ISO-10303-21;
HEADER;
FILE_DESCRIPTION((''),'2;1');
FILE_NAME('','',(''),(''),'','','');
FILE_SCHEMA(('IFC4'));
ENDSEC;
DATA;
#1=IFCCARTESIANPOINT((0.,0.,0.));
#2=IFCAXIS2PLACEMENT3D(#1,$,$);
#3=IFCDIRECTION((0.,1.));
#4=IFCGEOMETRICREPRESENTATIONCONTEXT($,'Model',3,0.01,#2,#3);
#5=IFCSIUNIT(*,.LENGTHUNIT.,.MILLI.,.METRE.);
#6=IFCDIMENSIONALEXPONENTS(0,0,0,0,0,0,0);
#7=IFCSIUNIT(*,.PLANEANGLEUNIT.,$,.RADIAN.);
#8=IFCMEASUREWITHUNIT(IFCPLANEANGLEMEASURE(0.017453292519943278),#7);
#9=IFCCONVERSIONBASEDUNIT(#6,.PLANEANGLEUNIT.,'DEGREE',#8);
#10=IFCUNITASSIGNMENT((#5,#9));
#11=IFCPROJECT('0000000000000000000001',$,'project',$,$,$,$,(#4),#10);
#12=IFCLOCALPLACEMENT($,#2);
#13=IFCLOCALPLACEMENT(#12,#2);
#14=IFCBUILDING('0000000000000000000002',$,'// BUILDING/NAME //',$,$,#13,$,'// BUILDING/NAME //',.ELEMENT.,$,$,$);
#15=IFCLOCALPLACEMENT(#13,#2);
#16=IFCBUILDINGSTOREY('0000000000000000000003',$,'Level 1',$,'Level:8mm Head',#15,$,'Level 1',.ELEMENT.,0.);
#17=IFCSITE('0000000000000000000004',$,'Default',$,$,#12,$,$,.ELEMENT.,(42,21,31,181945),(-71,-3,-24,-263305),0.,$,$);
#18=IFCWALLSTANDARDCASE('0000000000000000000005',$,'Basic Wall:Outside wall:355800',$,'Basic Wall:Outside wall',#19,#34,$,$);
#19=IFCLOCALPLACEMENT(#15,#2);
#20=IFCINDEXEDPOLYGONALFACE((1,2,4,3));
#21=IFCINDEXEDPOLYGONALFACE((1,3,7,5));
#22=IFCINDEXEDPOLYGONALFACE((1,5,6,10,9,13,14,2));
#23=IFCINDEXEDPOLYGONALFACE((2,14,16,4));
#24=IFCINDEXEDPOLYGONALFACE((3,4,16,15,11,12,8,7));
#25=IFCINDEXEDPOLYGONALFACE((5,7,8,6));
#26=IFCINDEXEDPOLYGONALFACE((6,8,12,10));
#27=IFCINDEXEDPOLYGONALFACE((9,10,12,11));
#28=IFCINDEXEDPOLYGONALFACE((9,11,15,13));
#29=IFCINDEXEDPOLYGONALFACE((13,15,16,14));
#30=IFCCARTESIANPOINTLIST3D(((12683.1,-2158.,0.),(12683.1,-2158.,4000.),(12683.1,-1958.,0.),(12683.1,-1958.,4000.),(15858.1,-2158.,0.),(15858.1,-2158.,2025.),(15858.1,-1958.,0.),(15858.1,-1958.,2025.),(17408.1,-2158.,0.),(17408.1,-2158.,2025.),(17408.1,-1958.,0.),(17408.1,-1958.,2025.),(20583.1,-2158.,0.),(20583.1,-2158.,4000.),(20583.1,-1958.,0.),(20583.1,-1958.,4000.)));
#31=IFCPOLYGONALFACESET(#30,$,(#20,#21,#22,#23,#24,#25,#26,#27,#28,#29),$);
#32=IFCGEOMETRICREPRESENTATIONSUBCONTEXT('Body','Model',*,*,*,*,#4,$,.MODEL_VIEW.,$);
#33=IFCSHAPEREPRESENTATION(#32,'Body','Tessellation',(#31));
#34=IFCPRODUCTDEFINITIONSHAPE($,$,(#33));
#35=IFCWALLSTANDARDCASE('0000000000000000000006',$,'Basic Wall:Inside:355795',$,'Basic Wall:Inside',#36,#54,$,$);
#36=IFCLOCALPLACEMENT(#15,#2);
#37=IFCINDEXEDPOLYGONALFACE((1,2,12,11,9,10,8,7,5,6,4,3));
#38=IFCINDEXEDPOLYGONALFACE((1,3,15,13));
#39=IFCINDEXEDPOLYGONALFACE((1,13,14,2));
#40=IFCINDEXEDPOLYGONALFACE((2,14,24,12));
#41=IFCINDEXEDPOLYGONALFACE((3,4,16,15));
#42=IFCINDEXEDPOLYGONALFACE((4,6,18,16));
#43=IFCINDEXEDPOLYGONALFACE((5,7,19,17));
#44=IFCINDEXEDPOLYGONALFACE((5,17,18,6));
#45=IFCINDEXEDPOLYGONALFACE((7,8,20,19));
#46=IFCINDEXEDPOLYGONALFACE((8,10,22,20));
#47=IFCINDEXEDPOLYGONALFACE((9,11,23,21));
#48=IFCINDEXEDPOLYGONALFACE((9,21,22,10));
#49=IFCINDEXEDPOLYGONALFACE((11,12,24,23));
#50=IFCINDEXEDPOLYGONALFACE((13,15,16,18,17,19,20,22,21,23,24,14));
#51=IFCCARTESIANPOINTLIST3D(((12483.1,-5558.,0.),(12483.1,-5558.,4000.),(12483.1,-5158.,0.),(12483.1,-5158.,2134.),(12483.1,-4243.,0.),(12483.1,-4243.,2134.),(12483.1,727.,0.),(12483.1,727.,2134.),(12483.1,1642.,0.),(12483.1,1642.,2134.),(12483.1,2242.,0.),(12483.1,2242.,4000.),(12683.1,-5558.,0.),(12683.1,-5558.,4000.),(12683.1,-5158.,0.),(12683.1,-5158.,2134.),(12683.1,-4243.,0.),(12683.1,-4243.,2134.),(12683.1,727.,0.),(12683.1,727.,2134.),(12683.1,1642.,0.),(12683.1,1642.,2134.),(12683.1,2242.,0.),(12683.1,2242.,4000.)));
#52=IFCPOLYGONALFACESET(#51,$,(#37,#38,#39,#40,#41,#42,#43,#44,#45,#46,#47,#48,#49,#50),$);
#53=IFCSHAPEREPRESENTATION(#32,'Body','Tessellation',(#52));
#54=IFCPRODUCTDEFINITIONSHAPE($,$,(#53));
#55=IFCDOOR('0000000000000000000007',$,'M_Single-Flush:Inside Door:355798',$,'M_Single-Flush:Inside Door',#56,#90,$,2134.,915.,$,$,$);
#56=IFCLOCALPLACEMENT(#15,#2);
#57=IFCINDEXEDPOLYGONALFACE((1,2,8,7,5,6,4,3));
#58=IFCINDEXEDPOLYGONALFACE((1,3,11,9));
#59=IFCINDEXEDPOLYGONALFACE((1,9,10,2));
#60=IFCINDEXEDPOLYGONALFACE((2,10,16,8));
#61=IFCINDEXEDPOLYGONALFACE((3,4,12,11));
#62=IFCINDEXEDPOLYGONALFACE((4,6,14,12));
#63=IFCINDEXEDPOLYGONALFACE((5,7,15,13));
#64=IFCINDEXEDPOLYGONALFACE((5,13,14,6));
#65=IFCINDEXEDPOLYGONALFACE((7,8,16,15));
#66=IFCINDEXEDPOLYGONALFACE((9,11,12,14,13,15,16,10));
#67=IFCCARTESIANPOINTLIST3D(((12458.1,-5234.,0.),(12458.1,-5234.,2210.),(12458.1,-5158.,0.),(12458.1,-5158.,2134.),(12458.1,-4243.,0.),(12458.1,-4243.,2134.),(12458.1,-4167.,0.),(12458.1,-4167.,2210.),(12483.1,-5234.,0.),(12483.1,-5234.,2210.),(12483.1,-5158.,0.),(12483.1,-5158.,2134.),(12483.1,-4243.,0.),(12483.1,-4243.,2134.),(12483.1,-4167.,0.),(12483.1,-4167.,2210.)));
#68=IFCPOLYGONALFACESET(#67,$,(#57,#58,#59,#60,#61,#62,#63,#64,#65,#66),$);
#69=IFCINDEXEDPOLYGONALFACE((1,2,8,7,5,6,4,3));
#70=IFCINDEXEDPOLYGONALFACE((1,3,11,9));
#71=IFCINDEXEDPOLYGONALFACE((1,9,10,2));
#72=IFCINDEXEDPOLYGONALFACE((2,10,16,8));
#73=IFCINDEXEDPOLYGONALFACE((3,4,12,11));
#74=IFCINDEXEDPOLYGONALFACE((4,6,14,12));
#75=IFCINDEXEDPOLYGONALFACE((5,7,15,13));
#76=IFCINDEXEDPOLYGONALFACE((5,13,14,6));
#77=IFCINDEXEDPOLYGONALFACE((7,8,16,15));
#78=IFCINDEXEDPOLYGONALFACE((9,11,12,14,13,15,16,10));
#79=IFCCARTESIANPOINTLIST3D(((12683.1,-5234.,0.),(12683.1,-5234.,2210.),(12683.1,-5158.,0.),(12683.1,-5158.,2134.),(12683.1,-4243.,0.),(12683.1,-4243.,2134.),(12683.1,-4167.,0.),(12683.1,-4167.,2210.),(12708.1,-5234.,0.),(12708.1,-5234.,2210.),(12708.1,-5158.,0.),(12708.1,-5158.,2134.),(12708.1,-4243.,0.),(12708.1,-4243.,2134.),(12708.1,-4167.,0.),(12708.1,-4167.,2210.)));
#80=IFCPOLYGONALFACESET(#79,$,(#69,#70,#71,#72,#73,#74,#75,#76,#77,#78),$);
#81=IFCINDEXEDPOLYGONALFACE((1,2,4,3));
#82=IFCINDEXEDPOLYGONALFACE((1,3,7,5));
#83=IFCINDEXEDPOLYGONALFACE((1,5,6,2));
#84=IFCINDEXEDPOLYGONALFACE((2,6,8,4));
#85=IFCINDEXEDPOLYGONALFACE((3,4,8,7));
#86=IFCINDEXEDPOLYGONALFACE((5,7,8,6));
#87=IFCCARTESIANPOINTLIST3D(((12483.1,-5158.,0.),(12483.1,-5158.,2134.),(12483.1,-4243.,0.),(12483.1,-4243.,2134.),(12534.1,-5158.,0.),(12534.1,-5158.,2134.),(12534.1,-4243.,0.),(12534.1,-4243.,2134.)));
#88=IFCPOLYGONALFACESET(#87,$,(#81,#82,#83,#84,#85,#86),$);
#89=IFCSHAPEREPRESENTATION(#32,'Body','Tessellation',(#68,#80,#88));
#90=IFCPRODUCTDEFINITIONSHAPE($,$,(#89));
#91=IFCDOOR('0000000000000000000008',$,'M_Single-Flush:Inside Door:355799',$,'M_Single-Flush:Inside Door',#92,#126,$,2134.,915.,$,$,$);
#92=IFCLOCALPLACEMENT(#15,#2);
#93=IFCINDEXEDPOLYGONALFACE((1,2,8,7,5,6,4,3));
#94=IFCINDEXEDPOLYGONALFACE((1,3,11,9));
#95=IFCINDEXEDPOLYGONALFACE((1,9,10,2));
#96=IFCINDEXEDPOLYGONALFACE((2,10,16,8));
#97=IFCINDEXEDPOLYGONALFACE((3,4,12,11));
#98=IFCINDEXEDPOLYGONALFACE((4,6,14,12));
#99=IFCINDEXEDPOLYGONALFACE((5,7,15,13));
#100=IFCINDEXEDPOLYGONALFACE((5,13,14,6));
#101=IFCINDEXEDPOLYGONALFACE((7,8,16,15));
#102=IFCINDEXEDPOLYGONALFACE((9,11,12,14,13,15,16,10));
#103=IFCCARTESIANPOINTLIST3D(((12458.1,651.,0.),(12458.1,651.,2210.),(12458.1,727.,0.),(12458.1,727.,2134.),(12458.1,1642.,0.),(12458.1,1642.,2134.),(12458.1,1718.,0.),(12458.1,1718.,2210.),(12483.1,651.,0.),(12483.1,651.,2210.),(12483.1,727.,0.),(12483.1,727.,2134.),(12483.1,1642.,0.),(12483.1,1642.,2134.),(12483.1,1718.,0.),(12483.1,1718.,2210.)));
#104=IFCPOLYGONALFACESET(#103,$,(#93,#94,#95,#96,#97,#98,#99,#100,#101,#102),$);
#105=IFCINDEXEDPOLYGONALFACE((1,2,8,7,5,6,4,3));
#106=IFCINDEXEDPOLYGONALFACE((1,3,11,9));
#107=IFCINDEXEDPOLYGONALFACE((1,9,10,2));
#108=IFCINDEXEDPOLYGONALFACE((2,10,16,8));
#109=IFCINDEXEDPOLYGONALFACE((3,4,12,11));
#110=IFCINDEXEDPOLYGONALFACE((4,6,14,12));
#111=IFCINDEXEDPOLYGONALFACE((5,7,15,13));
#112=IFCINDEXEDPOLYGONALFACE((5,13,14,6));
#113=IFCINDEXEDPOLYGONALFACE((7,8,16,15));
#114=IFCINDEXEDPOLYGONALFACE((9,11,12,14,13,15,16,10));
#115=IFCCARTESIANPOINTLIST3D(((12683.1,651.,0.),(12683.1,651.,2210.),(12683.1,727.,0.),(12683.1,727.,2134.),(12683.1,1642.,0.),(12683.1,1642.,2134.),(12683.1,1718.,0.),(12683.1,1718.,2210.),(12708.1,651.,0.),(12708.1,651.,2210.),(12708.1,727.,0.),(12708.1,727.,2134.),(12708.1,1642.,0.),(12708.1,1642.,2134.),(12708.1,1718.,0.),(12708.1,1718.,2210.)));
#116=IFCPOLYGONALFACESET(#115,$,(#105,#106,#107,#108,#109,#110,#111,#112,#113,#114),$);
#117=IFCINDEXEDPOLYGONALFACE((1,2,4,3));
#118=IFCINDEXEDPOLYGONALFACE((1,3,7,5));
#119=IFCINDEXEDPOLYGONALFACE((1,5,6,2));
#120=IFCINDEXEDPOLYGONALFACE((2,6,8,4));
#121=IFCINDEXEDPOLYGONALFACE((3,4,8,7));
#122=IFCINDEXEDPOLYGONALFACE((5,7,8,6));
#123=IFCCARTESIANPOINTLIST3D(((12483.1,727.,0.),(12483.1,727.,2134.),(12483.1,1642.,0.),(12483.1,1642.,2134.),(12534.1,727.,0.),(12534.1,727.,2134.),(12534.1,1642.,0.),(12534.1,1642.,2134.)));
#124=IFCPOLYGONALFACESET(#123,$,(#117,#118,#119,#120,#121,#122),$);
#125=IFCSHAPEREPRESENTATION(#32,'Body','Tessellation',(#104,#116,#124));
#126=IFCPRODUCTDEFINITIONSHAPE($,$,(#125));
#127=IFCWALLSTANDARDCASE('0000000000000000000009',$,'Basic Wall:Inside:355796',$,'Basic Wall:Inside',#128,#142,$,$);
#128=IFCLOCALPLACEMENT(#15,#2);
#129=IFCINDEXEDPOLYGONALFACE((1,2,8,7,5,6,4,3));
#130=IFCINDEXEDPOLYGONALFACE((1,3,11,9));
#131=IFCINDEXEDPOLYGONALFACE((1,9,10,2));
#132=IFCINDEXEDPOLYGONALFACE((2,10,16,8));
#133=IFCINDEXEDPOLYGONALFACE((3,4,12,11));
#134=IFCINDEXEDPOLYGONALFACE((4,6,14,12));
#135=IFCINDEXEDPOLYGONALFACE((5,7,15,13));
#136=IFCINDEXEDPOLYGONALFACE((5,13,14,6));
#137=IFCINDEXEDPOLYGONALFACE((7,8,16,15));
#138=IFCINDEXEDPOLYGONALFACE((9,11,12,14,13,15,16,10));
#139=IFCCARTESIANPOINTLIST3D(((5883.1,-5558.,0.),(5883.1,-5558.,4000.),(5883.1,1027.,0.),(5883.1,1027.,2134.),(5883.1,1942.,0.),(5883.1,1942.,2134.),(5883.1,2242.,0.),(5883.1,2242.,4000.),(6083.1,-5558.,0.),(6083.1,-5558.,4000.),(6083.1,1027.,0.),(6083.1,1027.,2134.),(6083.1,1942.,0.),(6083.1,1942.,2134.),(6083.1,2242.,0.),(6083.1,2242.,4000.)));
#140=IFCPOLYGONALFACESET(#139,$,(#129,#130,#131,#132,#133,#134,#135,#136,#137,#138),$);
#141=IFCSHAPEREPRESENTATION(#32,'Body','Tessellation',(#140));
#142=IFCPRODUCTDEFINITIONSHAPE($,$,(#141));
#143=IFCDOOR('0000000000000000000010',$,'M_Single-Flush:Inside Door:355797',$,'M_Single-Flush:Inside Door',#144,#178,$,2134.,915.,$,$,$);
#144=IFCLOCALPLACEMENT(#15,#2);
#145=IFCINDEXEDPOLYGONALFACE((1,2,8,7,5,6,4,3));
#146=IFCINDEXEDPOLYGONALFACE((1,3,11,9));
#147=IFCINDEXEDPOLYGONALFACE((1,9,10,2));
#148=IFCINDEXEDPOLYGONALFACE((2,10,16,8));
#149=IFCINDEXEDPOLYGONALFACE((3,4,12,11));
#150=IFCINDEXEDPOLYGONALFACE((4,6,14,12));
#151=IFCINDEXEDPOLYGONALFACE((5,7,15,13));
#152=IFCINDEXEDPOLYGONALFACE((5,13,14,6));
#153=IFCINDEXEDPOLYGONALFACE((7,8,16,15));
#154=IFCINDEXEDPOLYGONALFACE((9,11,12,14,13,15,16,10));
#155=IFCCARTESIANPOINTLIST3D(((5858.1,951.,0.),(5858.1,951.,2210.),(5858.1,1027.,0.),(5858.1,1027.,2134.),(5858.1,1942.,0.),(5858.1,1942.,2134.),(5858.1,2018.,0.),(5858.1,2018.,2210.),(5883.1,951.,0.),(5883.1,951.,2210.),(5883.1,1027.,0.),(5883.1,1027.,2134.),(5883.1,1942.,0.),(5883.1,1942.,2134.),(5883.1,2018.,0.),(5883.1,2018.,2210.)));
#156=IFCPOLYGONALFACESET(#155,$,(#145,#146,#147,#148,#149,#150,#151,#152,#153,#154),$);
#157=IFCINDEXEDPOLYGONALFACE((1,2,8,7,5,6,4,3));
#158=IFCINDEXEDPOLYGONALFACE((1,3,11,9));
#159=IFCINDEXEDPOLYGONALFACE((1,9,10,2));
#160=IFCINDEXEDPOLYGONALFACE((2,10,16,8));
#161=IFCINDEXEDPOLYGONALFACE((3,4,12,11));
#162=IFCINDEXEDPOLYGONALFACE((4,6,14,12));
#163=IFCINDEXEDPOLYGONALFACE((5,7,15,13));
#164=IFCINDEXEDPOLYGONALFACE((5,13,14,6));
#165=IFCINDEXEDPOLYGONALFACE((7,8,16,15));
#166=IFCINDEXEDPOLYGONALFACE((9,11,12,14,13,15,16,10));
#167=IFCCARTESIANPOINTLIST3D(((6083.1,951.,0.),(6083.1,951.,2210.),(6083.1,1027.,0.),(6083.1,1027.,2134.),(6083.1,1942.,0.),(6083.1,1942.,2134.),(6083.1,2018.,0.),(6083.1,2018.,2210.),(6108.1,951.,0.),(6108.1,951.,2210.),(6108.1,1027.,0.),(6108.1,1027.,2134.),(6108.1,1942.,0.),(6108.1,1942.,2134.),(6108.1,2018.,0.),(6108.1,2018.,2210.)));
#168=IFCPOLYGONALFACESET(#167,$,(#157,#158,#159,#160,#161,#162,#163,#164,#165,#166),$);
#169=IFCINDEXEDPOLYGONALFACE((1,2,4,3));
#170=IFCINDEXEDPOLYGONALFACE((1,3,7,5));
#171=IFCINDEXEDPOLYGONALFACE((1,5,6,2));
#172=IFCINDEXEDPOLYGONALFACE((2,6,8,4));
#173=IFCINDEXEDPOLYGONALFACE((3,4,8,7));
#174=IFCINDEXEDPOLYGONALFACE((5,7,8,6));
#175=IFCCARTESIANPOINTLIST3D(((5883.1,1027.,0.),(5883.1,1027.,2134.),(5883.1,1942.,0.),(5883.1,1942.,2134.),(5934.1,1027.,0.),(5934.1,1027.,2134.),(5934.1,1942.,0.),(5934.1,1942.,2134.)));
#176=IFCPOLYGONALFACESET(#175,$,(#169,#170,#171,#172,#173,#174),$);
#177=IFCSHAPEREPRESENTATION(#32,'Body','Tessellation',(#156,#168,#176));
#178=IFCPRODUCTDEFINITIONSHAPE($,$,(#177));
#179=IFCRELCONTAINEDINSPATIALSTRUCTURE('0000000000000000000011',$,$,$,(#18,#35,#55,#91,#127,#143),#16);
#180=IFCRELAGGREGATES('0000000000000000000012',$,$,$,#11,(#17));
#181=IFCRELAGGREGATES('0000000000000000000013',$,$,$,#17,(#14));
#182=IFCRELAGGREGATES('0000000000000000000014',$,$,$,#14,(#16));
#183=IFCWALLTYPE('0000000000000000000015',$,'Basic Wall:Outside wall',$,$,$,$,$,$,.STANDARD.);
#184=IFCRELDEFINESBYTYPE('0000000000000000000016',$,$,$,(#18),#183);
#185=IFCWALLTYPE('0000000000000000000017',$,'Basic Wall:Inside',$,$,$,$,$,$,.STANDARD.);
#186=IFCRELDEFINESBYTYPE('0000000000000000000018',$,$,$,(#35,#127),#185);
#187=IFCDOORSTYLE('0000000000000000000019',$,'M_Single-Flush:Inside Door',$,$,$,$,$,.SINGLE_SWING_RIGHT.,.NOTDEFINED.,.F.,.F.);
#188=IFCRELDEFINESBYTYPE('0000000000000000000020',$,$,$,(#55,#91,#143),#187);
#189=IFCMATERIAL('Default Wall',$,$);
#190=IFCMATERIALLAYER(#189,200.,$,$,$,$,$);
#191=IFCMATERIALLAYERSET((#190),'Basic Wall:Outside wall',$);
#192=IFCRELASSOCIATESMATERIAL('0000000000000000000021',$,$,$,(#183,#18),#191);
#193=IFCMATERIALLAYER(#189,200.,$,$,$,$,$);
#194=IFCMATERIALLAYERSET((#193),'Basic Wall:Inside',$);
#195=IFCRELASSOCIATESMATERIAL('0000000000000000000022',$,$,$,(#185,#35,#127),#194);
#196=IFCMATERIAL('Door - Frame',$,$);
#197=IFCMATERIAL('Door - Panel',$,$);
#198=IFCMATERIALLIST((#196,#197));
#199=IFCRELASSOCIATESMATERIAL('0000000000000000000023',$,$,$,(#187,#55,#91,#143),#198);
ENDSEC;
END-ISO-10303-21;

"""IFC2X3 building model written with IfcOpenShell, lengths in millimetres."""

from ifc_helpers import new_model, entity, si_unit, converted_unit, direction, frame, frame_2d, origin, place, context, subcontext, project, spatial, polyline, rectangle, outline, extrude, source, transform, mapped, material, material_list, layer, layer_set, layer_usage, type_object, type_shapes, element, fill, save


model = new_model("IFC2X3")

# Units and contexts
model_context = context("Model", 3, precision=0.01, world=origin(), true_north=direction((0.0, 1.0)))
body_context = subcontext(model_context, "Body", "Model", "MODEL_VIEW")
ifc_project = project(units=[si_unit("LENGTHUNIT", "METRE", prefix="MILLI"), converted_unit("PLANEANGLEUNIT", "DEGREE", entity("IfcPlaneAngleMeasure", 0.017453292519943278), si_unit("PLANEANGLEUNIT", "RADIAN"), dimensions=[0, 0, 0, 0, 0, 0, 0])], contexts=[model_context])

# Site, building, storey
site_placement = place(None, origin())
site = spatial("IfcSite", under=ifc_project, at=site_placement, Name="Default", CompositionType="ELEMENT", RefLatitude=(42, 21, 31, 181945), RefLongitude=(-71, -3, -24, -263305), RefElevation=0.0)
building_placement = place(site_placement, origin())
building = spatial("IfcBuilding", under=site, at=building_placement, Name="// BUILDING/NAME //", LongName="// BUILDING/NAME //", CompositionType="ELEMENT")
storey_placement = place(building_placement, origin())
storey = spatial("IfcBuildingStorey", under=building, at=storey_placement, Name="Level 1", ObjectType="Level:8mm Head", LongName="Level 1", CompositionType="ELEMENT", Elevation=0.0)

# Wall, opening
ifc_material_1 = material(Name="Default Wall")
ifc_layer_1 = layer(ifc_material_1, 200.0)
ifc_layer_set_1 = layer_set([ifc_layer_1], Name="Basic Wall:Outside wall")
ifc_layer_usage_1 = layer_usage(ifc_layer_set_1, "AXIS2", "NEGATIVE", 100.0)
wall_type_1 = type_object("IfcWallType", Name="Basic Wall:Outside wall", PredefinedType="STANDARD", material=ifc_layer_set_1)
wall_1_placement = place(storey_placement, frame((12683.1, -2058.0, 0.0)))
wall_1 = element("IfcWallStandardCase", 1, at=wall_1_placement, inside=storey, type_object=wall_type_1, material=ifc_layer_usage_1, Name="Basic Wall:Outside wall:355800", ObjectType="Basic Wall:Outside wall", context=body_context, shape_type="SweptSolid", body=[
    extrude(rectangle(XDim=7900.0, YDim=200.0, at=frame_2d((3950.0, 0.0), x_axis=(1.0, 0.0))), origin(), (0.0, 0.0, 1.0), 4000.0),
])
opening_1_placement = place(wall_1_placement, frame((4725.0, 100.0, 0.0)))
element("IfcOpeningElement", 2, at=opening_1_placement, cuts=wall_1, ObjectType="Opening", context=body_context, shape_type="SweptSolid", body=[
    extrude(rectangle(XDim=2025.0, YDim=1550.0, at=frame_2d((1012.5, 775.0), x_axis=(1.0, 0.0))), frame((0.0, 0.0, 0.0), z_axis=(0.0, -1.0, 0.0), x_axis=(0.0, 0.0, 1.0)), (0.0, 0.0, 1.0), 200.0),
])

# Wall, openings, doors
ifc_layer_2 = layer(ifc_material_1, 200.0)
ifc_layer_set_2 = layer_set([ifc_layer_2], Name="Basic Wall:Inside")
ifc_layer_usage_2 = layer_usage(ifc_layer_set_2, "AXIS2", "NEGATIVE", 100.0)
wall_type_2 = type_object("IfcWallType", Name="Basic Wall:Inside", PredefinedType="STANDARD", material=ifc_layer_set_2)
wall_2_placement = place(storey_placement, frame((12583.1, -5558.0, 0.0), z_axis=(0.0, 0.0, 1.0), x_axis=(0.0, 1.0, 0.0)))
wall_2 = element("IfcWallStandardCase", 3, at=wall_2_placement, inside=storey, type_object=wall_type_2, material=ifc_layer_usage_2, Name="Basic Wall:Inside:355795", ObjectType="Basic Wall:Inside", context=body_context, shape_type="SweptSolid", body=[
    extrude(rectangle(XDim=7800.0, YDim=200.0, at=frame_2d((3900.0, 0.0), x_axis=(1.0, 0.0))), origin(), (0.0, 0.0, 1.0), 4000.0),
])
opening_2_placement = place(wall_2_placement, frame((400.0, -100.0, 0.0)))
opening_2 = element("IfcOpeningElement", 4, at=opening_2_placement, cuts=wall_2, ObjectType="Opening", context=body_context, shape_type="SweptSolid", body=[
    extrude(rectangle(XDim=915.0, YDim=2134.0, at=frame_2d((1067.0, 457.5), x_axis=(0.0, 1.0))), frame((0.0, 0.0, 0.0), z_axis=(0.0, 1.0, 0.0), x_axis=(0.0, 0.0, 1.0)), (0.0, 0.0, 1.0), 200.0),
])
opening_3_placement = place(wall_2_placement, frame((6285.0, -100.0, 0.0)))
opening_3 = element("IfcOpeningElement", 5, at=opening_3_placement, cuts=wall_2, ObjectType="Opening", context=body_context, shape_type="SweptSolid", body=[
    extrude(rectangle(XDim=915.0, YDim=2134.0, at=frame_2d((1067.0, 457.5), x_axis=(0.0, 1.0))), frame((0.0, 0.0, 0.0), z_axis=(0.0, 1.0, 0.0), x_axis=(0.0, 0.0, 1.0)), (0.0, 0.0, 1.0), 200.0),
])
ifc_material_2 = material(Name="Door - Frame")
ifc_material_3 = material(Name="Door - Panel")
ifc_material_list = material_list([ifc_material_2, ifc_material_3])
door_style = type_object("IfcDoorStyle", Name="M_Single-Flush:Inside Door", ConstructionType="NOTDEFINED", OperationType="SINGLE_SWING_RIGHT", ParameterTakesPrecedence=False, Sizeable=False, material=ifc_material_list)
shared_shape = source(origin(), body_context, "Body", "SweptSolid", [
    extrude(outline(polyline([(-533.5, -1124.0), (533.5, -1124.0), (533.5, 1086.0), (457.5, 1086.0), (457.5, -1048.0), (-457.5, -1048.0), (-457.5, 1086.0), (-533.5, 1086.0), (-533.5, -1124.0)])), frame((457.5, 200.0, 1086.0), z_axis=(0.0, 1.0, 0.0), x_axis=(1.0, 0.0, 0.0)), (0.0, 0.0, 1.0), 25.0),
    extrude(outline(polyline([(-1124.0, -533.5), (1086.0, -533.5), (1086.0, -457.5), (-1048.0, -457.5), (-1048.0, 457.5), (1086.0, 457.5), (1086.0, 533.5), (-1124.0, 533.5), (-1124.0, -533.5)])), frame((457.5, -25.0, 1086.0), z_axis=(0.0, 1.0, 0.0), x_axis=(0.0, 0.0, -1.0)), (0.0, 0.0, 1.0), 25.0),
    extrude(rectangle(XDim=51.0, YDim=915.0, at=frame_2d((0.0, 0.0), x_axis=(1.0, 0.0))), frame((457.5, 174.5, 0.0), z_axis=(0.0, 0.0, 1.0), x_axis=(0.0, 1.0, 0.0)), (0.0, 0.0, 1.0), 2134.0),
])
type_shapes(door_style, [shared_shape])
door_1_placement = place(opening_2_placement, origin())
door_1 = element("IfcDoor", 6, at=door_1_placement, inside=storey, type_object=door_style, material=ifc_material_list, Name="M_Single-Flush:Inside Door:355798", ObjectType="M_Single-Flush:Inside Door", OverallHeight=2134.0, OverallWidth=915.0, context=body_context, shape_type="MappedRepresentation", body=[
    mapped(shared_shape, transform((0.0, 0.0, 0.0), scale=1.0)),
])
fill(opening_2, door_1)
door_2_placement = place(opening_3_placement, origin())
door_2 = element("IfcDoor", 7, at=door_2_placement, inside=storey, type_object=door_style, material=ifc_material_list, Name="M_Single-Flush:Inside Door:355799", ObjectType="M_Single-Flush:Inside Door", OverallHeight=2134.0, OverallWidth=915.0, context=body_context, shape_type="MappedRepresentation", body=[
    mapped(shared_shape, transform((0.0, 0.0, 0.0), scale=1.0)),
])
fill(opening_3, door_2)

# Wall, opening, door
wall_3_placement = place(storey_placement, frame((5983.1, -5558.0, 0.0), z_axis=(0.0, 0.0, 1.0), x_axis=(0.0, 1.0, 0.0)))
wall_3 = element("IfcWallStandardCase", 8, at=wall_3_placement, inside=storey, type_object=wall_type_2, material=ifc_layer_usage_2, Name="Basic Wall:Inside:355796", ObjectType="Basic Wall:Inside", context=body_context, shape_type="SweptSolid", body=[
    extrude(rectangle(XDim=7800.0, YDim=200.0, at=frame_2d((3900.0, 0.0), x_axis=(-1.0, 0.0))), origin(), (0.0, 0.0, 1.0), 4000.0),
])
opening_4_placement = place(wall_3_placement, frame((6585.0, -100.0, 0.0)))
opening_4 = element("IfcOpeningElement", 9, at=opening_4_placement, cuts=wall_3, ObjectType="Opening", context=body_context, shape_type="SweptSolid", body=[
    extrude(rectangle(XDim=915.0, YDim=2134.0, at=frame_2d((1067.0, 457.5), x_axis=(0.0, 1.0))), frame((0.0, 0.0, 0.0), z_axis=(0.0, 1.0, 0.0), x_axis=(0.0, 0.0, 1.0)), (0.0, 0.0, 1.0), 200.0),
])
door_3_placement = place(opening_4_placement, origin())
door_3 = element("IfcDoor", 10, at=door_3_placement, inside=storey, type_object=door_style, material=ifc_material_list, Name="M_Single-Flush:Inside Door:355797", ObjectType="M_Single-Flush:Inside Door", OverallHeight=2134.0, OverallWidth=915.0, context=body_context, shape_type="MappedRepresentation", body=[
    mapped(shared_shape, transform((0.0, 0.0, 0.0), scale=1.0)),
])
fill(opening_4, door_3)

save(model, "model.ifc")
